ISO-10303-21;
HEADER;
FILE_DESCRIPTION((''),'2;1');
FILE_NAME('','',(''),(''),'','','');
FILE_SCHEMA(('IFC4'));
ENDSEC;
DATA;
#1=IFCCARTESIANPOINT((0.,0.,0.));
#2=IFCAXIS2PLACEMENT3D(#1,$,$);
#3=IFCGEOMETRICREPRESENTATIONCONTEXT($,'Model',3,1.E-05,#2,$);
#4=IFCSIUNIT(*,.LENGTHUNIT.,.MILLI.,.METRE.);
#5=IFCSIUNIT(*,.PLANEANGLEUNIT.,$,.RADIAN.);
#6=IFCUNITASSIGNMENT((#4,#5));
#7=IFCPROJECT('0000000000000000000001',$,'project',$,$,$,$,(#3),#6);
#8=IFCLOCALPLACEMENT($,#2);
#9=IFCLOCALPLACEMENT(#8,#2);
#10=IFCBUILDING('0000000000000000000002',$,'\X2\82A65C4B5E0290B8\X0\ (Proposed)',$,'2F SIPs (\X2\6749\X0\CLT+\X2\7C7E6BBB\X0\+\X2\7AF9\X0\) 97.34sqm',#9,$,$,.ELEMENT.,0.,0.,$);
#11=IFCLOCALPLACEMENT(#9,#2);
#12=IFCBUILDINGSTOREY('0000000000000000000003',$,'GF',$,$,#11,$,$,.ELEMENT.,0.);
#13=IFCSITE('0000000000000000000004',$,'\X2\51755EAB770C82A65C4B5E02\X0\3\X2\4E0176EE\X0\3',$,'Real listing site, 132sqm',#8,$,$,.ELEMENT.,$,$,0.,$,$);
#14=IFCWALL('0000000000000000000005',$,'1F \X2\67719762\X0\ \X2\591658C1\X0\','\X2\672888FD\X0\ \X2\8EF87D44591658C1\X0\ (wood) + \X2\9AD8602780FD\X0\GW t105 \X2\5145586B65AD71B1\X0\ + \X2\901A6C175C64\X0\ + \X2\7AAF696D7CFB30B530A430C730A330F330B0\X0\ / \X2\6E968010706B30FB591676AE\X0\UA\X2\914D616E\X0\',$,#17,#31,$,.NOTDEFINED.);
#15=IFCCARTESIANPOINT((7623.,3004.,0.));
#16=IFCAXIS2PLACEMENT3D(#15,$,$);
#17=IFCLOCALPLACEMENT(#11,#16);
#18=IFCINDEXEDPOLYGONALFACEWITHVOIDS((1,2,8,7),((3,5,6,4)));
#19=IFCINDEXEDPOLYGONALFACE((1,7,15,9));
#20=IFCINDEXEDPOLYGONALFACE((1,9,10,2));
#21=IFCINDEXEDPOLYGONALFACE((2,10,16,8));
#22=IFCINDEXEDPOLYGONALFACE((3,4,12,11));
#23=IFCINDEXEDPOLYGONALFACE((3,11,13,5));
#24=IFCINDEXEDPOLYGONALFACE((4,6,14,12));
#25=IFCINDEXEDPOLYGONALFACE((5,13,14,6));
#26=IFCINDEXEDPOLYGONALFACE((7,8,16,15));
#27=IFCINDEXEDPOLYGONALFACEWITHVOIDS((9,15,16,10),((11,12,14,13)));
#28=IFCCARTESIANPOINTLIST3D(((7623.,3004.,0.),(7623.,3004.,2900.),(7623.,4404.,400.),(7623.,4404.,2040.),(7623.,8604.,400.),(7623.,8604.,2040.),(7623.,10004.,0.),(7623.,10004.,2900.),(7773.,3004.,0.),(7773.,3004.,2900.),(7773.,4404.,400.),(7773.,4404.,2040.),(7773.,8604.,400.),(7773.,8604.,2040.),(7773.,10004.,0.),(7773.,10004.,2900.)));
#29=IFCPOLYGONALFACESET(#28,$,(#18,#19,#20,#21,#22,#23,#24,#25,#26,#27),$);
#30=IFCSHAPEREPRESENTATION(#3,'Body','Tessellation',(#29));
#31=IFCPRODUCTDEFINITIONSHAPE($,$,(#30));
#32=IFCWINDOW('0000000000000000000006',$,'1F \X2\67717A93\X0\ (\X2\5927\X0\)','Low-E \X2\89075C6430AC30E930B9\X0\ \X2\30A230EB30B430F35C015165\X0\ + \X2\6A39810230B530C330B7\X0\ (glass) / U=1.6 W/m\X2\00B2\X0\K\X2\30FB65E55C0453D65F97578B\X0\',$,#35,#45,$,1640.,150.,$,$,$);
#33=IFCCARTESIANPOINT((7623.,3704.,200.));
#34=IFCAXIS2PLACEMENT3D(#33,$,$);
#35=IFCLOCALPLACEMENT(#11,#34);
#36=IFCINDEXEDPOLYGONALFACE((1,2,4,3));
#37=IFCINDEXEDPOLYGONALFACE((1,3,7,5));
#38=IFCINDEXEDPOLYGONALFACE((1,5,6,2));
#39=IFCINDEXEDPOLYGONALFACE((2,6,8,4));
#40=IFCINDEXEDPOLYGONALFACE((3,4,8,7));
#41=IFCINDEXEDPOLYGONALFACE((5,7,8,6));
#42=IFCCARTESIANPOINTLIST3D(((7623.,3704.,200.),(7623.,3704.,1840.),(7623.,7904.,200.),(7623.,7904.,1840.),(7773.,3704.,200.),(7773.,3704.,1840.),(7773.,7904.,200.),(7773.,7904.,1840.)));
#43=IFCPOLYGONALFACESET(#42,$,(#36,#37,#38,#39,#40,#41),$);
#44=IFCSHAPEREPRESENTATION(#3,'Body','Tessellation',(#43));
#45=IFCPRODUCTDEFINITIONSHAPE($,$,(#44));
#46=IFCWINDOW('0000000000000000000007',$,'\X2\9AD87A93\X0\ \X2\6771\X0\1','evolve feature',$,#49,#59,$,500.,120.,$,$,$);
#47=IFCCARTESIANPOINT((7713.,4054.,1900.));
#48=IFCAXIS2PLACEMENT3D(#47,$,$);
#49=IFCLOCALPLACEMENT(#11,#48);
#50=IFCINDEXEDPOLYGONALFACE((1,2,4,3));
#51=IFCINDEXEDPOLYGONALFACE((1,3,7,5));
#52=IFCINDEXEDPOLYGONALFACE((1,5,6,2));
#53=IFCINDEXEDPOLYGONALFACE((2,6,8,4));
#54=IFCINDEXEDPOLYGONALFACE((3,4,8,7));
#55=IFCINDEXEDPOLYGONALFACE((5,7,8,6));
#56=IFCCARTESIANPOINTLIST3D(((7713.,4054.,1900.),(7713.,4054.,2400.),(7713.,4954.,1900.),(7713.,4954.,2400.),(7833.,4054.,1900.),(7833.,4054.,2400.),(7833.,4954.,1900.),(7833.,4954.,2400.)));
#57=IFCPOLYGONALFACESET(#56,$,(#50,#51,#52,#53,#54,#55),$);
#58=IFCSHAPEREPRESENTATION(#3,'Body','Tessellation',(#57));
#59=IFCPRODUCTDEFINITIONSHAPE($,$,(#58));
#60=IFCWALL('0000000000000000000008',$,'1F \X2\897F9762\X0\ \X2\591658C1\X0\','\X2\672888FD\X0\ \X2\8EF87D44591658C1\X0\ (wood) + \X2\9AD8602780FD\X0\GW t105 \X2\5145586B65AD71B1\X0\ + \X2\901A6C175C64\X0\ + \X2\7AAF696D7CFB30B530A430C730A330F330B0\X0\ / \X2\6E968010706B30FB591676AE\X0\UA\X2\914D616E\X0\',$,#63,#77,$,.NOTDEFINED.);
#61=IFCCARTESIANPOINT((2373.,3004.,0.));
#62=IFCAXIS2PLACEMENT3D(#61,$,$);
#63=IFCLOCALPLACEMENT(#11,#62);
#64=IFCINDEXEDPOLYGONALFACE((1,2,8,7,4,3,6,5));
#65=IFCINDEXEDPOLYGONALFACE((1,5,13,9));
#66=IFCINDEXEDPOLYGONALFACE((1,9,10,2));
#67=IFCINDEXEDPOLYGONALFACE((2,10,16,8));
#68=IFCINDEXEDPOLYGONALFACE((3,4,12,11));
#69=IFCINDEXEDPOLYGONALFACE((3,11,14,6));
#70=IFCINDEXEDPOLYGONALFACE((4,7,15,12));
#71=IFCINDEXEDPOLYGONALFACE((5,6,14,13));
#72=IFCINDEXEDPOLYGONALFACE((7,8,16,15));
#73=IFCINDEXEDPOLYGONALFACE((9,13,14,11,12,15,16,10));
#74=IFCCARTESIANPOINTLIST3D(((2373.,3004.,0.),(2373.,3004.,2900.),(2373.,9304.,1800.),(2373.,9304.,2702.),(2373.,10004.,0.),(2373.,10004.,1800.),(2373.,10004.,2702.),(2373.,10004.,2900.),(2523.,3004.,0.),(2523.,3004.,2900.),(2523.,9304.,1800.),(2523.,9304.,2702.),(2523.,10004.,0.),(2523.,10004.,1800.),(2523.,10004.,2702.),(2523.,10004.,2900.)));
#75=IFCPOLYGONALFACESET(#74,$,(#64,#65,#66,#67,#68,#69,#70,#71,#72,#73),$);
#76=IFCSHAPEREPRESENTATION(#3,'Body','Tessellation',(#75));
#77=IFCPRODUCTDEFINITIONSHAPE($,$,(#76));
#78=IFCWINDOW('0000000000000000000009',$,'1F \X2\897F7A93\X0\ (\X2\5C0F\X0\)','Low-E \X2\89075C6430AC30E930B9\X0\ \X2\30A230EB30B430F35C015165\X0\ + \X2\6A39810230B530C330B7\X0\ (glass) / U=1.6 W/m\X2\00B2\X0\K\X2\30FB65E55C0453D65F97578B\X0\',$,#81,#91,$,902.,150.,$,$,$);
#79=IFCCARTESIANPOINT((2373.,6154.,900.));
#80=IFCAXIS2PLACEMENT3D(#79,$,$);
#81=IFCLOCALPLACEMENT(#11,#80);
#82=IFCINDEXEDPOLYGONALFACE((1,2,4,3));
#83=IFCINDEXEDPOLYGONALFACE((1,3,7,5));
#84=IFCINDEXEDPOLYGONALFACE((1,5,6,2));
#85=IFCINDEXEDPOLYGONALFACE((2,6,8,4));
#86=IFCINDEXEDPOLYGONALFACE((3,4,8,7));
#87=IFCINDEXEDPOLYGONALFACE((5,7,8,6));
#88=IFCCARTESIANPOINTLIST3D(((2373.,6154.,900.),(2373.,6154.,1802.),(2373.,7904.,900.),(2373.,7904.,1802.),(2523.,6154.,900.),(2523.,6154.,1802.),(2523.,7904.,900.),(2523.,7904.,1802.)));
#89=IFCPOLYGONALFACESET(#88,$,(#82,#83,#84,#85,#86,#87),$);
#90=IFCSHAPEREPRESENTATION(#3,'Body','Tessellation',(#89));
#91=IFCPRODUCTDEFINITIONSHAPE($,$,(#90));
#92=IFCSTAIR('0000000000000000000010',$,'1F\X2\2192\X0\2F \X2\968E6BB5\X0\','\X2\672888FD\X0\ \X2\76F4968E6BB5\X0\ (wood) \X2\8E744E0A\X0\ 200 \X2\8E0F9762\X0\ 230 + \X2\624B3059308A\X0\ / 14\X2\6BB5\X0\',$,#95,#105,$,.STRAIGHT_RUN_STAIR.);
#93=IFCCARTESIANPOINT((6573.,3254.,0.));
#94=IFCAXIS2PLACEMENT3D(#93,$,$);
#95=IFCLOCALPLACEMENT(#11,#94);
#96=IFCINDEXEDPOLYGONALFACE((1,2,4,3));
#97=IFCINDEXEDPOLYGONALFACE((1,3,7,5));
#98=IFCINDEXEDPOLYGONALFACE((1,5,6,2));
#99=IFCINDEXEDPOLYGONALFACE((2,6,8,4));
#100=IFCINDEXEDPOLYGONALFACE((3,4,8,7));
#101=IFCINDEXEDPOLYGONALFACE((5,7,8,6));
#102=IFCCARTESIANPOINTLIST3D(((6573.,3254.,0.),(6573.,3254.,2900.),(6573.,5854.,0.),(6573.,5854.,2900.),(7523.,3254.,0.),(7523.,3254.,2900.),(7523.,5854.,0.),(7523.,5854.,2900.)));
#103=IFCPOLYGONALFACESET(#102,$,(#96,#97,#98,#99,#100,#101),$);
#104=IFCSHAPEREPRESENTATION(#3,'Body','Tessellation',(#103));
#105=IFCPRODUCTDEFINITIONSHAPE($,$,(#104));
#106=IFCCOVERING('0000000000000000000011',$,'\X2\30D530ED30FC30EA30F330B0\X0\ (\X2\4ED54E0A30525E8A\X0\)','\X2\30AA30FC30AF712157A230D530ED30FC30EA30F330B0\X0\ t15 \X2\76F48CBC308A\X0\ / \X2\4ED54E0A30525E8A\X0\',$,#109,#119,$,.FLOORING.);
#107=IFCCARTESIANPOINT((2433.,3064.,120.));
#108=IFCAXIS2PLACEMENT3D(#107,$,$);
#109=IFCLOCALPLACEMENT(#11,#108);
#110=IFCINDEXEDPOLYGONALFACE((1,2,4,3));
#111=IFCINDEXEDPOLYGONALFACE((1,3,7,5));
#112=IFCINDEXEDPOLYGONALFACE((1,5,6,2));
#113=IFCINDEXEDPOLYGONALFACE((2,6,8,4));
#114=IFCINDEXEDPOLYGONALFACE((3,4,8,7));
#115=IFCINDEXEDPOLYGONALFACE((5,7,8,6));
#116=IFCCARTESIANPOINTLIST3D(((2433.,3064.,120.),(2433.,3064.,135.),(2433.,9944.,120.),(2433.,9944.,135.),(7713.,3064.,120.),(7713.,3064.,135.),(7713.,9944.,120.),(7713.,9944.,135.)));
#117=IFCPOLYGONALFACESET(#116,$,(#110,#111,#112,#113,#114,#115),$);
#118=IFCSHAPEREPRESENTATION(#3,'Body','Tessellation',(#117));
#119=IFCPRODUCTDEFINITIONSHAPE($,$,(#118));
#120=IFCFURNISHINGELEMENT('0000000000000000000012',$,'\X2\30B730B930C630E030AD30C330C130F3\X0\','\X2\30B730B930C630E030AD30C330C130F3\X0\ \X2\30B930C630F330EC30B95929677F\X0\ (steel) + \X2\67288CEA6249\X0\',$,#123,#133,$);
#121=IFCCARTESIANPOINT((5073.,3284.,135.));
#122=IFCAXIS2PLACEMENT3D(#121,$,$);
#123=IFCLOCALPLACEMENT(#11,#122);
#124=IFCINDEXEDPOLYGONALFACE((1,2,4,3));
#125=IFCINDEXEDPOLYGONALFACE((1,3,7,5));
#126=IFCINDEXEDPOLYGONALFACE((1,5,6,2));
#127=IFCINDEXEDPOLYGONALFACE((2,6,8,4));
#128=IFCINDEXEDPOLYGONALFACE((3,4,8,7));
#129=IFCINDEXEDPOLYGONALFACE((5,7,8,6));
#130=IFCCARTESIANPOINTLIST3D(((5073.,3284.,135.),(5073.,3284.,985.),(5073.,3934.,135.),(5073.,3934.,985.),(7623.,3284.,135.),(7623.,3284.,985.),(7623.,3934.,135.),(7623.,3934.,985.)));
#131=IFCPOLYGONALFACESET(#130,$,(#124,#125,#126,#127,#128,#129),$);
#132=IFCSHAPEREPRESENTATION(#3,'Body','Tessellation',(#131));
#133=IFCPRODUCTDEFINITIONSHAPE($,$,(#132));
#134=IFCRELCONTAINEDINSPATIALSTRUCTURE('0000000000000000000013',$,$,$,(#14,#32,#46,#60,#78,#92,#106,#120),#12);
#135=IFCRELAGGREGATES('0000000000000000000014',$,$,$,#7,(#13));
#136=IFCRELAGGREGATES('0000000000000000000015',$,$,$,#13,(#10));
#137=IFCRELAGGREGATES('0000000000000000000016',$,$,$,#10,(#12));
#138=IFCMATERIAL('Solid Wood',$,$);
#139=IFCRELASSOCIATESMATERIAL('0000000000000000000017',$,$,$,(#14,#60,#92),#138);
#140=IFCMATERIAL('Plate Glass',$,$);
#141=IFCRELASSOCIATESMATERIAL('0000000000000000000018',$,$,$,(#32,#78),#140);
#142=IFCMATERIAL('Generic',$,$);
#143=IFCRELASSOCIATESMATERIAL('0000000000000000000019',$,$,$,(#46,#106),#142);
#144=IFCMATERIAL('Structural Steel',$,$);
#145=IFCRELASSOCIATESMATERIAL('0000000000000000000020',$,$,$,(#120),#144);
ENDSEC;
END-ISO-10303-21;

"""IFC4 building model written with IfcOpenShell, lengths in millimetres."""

from ifc_helpers import new_model, si_unit, frame, frame_2d, origin, place, context, project, spatial, rectangle, extrude, material, element, fill, save


model = new_model("IFC4")

# Units and contexts
model_context = context("Model", 3, precision=1e-05, world=origin())
ifc_project = project(units=[si_unit("LENGTHUNIT", "METRE", prefix="MILLI"), si_unit("PLANEANGLEUNIT", "RADIAN")], contexts=[model_context])

# Site, building, storey
site_placement = place(None, origin())
site = spatial("IfcSite", under=ifc_project, at=site_placement, Name="兵庫県芦屋市3丁目3", ObjectType="Real listing site, 132sqm", CompositionType="ELEMENT", RefElevation=0.0)
building_placement = place(site_placement, origin())
building = spatial("IfcBuilding", under=site, at=building_placement, Name="芦屋市邸 (Proposed)", ObjectType="2F SIPs (杉CLT+籾殻+竹) 97.34sqm", CompositionType="ELEMENT", ElevationOfRefHeight=0.0, ElevationOfTerrain=0.0)
storey_placement = place(building_placement, origin())
storey = spatial("IfcBuildingStorey", under=building, at=storey_placement, Name="GF", CompositionType="ELEMENT", Elevation=0.0)

# Shared definitions
ifc_material_1 = material(Name="Solid Wood")
ifc_material_2 = material(Name="Generic")

# Shared definitions
ifc_material_3 = material(Name="Plate Glass")

# Wall, openings, windows
wall_1_placement = place(storey_placement, frame((7623.0, 3004.0, 0.0)))
wall_1 = element("IfcWall", 1, at=wall_1_placement, inside=storey, material=ifc_material_1, Name="1F 東面 外壁", Description="木製 軸組外壁 (wood) + 高性能GW t105 充填断熱 + 通気層 + 窯業系サイディング / 準耐火・外皮UA配慮", PredefinedType="NOTDEFINED", context=model_context, shape_type="SweptSolid", body=[
    extrude(rectangle(XDim=150.0, YDim=7000.0, at=frame_2d((75.0, 3500.0))), frame((7623.0, 3004.0, 0.0)), (0.0, 0.0, 1.0), 2900.0),
])
opening_1_placement = place(storey_placement, frame((7623.0, 3704.0, 200.0)))
opening_1 = element("IfcOpeningElement", 2, at=opening_1_placement, cuts=wall_1, PredefinedType="NOTDEFINED", context=model_context, shape_type="SweptSolid", body=[
    extrude(rectangle(XDim=150.0, YDim=4200.0, at=frame_2d((75.0, 2100.0))), frame((7623.0, 3704.0, 200.0)), (0.0, 0.0, 1.0), 1640.0),
])
opening_2_placement = place(storey_placement, frame((7713.0, 4054.0, 1900.0)))
opening_2 = element("IfcOpeningElement", 3, at=opening_2_placement, cuts=wall_1, PredefinedType="NOTDEFINED", context=model_context, shape_type="SweptSolid", body=[
    extrude(rectangle(XDim=120.0, YDim=900.0, at=frame_2d((60.0, 450.0))), frame((7713.0, 4054.0, 1900.0)), (0.0, 0.0, 1.0), 500.0),
])
window_1_placement = place(storey_placement, frame((7623.0, 3704.0, 200.0)))
window_1 = element("IfcWindow", 4, at=window_1_placement, inside=storey, material=ifc_material_3, Name="1F 東窓 (大)", Description="Low-E 複層ガラス アルゴン封入 + 樹脂サッシ (glass) / U=1.6 W/m²K・日射取得型", OverallHeight=1640.0, OverallWidth=150.0, context=model_context, shape_type="SweptSolid", body=[
    extrude(rectangle(XDim=150.0, YDim=4200.0, at=frame_2d((75.0, 2100.0))), frame((7623.0, 3704.0, 200.0)), (0.0, 0.0, 1.0), 1640.0),
])
fill(opening_1, window_1)
window_2_placement = place(storey_placement, frame((7713.0, 4054.0, 1900.0)))
window_2 = element("IfcWindow", 5, at=window_2_placement, inside=storey, material=ifc_material_2, Name="高窓 東1", Description="evolve feature", OverallHeight=500.0, OverallWidth=120.0, context=model_context, shape_type="SweptSolid", body=[
    extrude(rectangle(XDim=120.0, YDim=900.0, at=frame_2d((60.0, 450.0))), frame((7713.0, 4054.0, 1900.0)), (0.0, 0.0, 1.0), 500.0),
])
fill(opening_2, window_2)

# Wall, opening, window
wall_2_placement = place(storey_placement, frame((2373.0, 3004.0, 0.0)))
wall_2 = element("IfcWall", 6, at=wall_2_placement, inside=storey, material=ifc_material_1, Name="1F 西面 外壁", Description="木製 軸組外壁 (wood) + 高性能GW t105 充填断熱 + 通気層 + 窯業系サイディング / 準耐火・外皮UA配慮", PredefinedType="NOTDEFINED", context=model_context, shape_type="SweptSolid", body=[
    extrude(rectangle(XDim=150.0, YDim=7000.0, at=frame_2d((75.0, 3500.0))), frame((2373.0, 3004.0, 0.0)), (0.0, 0.0, 1.0), 2900.0),
])
opening_3_placement = place(storey_placement, frame((2373.0, 6154.0, 900.0)))
opening_3 = element("IfcOpeningElement", 7, at=opening_3_placement, cuts=wall_2, PredefinedType="NOTDEFINED", context=model_context, shape_type="SweptSolid", body=[
    extrude(rectangle(XDim=150.0, YDim=1750.0, at=frame_2d((75.0, 875.0))), frame((2373.0, 6154.0, 900.0)), (0.0, 0.0, 1.0), 902.0),
])
window_3_placement = place(storey_placement, frame((2373.0, 6154.0, 900.0)))
window_3 = element("IfcWindow", 8, at=window_3_placement, inside=storey, material=ifc_material_3, Name="1F 西窓 (小)", Description="Low-E 複層ガラス アルゴン封入 + 樹脂サッシ (glass) / U=1.6 W/m²K・日射取得型", OverallHeight=902.0, OverallWidth=150.0, context=model_context, shape_type="SweptSolid", body=[
    extrude(rectangle(XDim=150.0, YDim=1750.0, at=frame_2d((75.0, 875.0))), frame((2373.0, 6154.0, 900.0)), (0.0, 0.0, 1.0), 902.0),
])
fill(opening_3, window_3)

# Stair
stair_placement = place(storey_placement, frame((6573.0, 3254.0, 0.0)))
element("IfcStair", 9, at=stair_placement, inside=storey, material=ifc_material_1, Name="1F→2F 階段", Description="木製 直階段 (wood) 蹴上 200 踏面 230 + 手すり / 14段", PredefinedType="STRAIGHT_RUN_STAIR", context=model_context, shape_type="SweptSolid", body=[
    extrude(rectangle(XDim=950.0, YDim=2600.0, at=frame_2d((475.0, 1300.0))), frame((6573.0, 3254.0, 0.0)), (0.0, 0.0, 1.0), 2900.0),
])

# Covering
covering_placement = place(storey_placement, frame((2433.0, 3064.0, 120.0)))
element("IfcCovering", 10, at=covering_placement, inside=storey, material=ifc_material_2, Name="フローリング (仕上げ床)", Description="オーク無垢フローリング t15 直貼り / 仕上げ床", PredefinedType="FLOORING", context=model_context, shape_type="SweptSolid", body=[
    extrude(rectangle(XDim=5280.0, YDim=6880.0, at=frame_2d((2640.0, 3440.0))), frame((2433.0, 3064.0, 120.0)), (0.0, 0.0, 1.0), 15.0),
])

# Furnishing element
ifc_material_4 = material(Name="Structural Steel")
furnishing_placement = place(storey_placement, frame((5073.0, 3284.0, 135.0)))
element("IfcFurnishingElement", 11, at=furnishing_placement, inside=storey, material=ifc_material_4, Name="システムキッチン", Description="システムキッチン ステンレス天板 (steel) + 木質扉", context=model_context, shape_type="SweptSolid", body=[
    extrude(rectangle(XDim=2550.0, YDim=650.0, at=frame_2d((1275.0, 325.0))), frame((5073.0, 3284.0, 135.0)), (0.0, 0.0, 1.0), 850.0),
])

save(model, "model.ifc")
